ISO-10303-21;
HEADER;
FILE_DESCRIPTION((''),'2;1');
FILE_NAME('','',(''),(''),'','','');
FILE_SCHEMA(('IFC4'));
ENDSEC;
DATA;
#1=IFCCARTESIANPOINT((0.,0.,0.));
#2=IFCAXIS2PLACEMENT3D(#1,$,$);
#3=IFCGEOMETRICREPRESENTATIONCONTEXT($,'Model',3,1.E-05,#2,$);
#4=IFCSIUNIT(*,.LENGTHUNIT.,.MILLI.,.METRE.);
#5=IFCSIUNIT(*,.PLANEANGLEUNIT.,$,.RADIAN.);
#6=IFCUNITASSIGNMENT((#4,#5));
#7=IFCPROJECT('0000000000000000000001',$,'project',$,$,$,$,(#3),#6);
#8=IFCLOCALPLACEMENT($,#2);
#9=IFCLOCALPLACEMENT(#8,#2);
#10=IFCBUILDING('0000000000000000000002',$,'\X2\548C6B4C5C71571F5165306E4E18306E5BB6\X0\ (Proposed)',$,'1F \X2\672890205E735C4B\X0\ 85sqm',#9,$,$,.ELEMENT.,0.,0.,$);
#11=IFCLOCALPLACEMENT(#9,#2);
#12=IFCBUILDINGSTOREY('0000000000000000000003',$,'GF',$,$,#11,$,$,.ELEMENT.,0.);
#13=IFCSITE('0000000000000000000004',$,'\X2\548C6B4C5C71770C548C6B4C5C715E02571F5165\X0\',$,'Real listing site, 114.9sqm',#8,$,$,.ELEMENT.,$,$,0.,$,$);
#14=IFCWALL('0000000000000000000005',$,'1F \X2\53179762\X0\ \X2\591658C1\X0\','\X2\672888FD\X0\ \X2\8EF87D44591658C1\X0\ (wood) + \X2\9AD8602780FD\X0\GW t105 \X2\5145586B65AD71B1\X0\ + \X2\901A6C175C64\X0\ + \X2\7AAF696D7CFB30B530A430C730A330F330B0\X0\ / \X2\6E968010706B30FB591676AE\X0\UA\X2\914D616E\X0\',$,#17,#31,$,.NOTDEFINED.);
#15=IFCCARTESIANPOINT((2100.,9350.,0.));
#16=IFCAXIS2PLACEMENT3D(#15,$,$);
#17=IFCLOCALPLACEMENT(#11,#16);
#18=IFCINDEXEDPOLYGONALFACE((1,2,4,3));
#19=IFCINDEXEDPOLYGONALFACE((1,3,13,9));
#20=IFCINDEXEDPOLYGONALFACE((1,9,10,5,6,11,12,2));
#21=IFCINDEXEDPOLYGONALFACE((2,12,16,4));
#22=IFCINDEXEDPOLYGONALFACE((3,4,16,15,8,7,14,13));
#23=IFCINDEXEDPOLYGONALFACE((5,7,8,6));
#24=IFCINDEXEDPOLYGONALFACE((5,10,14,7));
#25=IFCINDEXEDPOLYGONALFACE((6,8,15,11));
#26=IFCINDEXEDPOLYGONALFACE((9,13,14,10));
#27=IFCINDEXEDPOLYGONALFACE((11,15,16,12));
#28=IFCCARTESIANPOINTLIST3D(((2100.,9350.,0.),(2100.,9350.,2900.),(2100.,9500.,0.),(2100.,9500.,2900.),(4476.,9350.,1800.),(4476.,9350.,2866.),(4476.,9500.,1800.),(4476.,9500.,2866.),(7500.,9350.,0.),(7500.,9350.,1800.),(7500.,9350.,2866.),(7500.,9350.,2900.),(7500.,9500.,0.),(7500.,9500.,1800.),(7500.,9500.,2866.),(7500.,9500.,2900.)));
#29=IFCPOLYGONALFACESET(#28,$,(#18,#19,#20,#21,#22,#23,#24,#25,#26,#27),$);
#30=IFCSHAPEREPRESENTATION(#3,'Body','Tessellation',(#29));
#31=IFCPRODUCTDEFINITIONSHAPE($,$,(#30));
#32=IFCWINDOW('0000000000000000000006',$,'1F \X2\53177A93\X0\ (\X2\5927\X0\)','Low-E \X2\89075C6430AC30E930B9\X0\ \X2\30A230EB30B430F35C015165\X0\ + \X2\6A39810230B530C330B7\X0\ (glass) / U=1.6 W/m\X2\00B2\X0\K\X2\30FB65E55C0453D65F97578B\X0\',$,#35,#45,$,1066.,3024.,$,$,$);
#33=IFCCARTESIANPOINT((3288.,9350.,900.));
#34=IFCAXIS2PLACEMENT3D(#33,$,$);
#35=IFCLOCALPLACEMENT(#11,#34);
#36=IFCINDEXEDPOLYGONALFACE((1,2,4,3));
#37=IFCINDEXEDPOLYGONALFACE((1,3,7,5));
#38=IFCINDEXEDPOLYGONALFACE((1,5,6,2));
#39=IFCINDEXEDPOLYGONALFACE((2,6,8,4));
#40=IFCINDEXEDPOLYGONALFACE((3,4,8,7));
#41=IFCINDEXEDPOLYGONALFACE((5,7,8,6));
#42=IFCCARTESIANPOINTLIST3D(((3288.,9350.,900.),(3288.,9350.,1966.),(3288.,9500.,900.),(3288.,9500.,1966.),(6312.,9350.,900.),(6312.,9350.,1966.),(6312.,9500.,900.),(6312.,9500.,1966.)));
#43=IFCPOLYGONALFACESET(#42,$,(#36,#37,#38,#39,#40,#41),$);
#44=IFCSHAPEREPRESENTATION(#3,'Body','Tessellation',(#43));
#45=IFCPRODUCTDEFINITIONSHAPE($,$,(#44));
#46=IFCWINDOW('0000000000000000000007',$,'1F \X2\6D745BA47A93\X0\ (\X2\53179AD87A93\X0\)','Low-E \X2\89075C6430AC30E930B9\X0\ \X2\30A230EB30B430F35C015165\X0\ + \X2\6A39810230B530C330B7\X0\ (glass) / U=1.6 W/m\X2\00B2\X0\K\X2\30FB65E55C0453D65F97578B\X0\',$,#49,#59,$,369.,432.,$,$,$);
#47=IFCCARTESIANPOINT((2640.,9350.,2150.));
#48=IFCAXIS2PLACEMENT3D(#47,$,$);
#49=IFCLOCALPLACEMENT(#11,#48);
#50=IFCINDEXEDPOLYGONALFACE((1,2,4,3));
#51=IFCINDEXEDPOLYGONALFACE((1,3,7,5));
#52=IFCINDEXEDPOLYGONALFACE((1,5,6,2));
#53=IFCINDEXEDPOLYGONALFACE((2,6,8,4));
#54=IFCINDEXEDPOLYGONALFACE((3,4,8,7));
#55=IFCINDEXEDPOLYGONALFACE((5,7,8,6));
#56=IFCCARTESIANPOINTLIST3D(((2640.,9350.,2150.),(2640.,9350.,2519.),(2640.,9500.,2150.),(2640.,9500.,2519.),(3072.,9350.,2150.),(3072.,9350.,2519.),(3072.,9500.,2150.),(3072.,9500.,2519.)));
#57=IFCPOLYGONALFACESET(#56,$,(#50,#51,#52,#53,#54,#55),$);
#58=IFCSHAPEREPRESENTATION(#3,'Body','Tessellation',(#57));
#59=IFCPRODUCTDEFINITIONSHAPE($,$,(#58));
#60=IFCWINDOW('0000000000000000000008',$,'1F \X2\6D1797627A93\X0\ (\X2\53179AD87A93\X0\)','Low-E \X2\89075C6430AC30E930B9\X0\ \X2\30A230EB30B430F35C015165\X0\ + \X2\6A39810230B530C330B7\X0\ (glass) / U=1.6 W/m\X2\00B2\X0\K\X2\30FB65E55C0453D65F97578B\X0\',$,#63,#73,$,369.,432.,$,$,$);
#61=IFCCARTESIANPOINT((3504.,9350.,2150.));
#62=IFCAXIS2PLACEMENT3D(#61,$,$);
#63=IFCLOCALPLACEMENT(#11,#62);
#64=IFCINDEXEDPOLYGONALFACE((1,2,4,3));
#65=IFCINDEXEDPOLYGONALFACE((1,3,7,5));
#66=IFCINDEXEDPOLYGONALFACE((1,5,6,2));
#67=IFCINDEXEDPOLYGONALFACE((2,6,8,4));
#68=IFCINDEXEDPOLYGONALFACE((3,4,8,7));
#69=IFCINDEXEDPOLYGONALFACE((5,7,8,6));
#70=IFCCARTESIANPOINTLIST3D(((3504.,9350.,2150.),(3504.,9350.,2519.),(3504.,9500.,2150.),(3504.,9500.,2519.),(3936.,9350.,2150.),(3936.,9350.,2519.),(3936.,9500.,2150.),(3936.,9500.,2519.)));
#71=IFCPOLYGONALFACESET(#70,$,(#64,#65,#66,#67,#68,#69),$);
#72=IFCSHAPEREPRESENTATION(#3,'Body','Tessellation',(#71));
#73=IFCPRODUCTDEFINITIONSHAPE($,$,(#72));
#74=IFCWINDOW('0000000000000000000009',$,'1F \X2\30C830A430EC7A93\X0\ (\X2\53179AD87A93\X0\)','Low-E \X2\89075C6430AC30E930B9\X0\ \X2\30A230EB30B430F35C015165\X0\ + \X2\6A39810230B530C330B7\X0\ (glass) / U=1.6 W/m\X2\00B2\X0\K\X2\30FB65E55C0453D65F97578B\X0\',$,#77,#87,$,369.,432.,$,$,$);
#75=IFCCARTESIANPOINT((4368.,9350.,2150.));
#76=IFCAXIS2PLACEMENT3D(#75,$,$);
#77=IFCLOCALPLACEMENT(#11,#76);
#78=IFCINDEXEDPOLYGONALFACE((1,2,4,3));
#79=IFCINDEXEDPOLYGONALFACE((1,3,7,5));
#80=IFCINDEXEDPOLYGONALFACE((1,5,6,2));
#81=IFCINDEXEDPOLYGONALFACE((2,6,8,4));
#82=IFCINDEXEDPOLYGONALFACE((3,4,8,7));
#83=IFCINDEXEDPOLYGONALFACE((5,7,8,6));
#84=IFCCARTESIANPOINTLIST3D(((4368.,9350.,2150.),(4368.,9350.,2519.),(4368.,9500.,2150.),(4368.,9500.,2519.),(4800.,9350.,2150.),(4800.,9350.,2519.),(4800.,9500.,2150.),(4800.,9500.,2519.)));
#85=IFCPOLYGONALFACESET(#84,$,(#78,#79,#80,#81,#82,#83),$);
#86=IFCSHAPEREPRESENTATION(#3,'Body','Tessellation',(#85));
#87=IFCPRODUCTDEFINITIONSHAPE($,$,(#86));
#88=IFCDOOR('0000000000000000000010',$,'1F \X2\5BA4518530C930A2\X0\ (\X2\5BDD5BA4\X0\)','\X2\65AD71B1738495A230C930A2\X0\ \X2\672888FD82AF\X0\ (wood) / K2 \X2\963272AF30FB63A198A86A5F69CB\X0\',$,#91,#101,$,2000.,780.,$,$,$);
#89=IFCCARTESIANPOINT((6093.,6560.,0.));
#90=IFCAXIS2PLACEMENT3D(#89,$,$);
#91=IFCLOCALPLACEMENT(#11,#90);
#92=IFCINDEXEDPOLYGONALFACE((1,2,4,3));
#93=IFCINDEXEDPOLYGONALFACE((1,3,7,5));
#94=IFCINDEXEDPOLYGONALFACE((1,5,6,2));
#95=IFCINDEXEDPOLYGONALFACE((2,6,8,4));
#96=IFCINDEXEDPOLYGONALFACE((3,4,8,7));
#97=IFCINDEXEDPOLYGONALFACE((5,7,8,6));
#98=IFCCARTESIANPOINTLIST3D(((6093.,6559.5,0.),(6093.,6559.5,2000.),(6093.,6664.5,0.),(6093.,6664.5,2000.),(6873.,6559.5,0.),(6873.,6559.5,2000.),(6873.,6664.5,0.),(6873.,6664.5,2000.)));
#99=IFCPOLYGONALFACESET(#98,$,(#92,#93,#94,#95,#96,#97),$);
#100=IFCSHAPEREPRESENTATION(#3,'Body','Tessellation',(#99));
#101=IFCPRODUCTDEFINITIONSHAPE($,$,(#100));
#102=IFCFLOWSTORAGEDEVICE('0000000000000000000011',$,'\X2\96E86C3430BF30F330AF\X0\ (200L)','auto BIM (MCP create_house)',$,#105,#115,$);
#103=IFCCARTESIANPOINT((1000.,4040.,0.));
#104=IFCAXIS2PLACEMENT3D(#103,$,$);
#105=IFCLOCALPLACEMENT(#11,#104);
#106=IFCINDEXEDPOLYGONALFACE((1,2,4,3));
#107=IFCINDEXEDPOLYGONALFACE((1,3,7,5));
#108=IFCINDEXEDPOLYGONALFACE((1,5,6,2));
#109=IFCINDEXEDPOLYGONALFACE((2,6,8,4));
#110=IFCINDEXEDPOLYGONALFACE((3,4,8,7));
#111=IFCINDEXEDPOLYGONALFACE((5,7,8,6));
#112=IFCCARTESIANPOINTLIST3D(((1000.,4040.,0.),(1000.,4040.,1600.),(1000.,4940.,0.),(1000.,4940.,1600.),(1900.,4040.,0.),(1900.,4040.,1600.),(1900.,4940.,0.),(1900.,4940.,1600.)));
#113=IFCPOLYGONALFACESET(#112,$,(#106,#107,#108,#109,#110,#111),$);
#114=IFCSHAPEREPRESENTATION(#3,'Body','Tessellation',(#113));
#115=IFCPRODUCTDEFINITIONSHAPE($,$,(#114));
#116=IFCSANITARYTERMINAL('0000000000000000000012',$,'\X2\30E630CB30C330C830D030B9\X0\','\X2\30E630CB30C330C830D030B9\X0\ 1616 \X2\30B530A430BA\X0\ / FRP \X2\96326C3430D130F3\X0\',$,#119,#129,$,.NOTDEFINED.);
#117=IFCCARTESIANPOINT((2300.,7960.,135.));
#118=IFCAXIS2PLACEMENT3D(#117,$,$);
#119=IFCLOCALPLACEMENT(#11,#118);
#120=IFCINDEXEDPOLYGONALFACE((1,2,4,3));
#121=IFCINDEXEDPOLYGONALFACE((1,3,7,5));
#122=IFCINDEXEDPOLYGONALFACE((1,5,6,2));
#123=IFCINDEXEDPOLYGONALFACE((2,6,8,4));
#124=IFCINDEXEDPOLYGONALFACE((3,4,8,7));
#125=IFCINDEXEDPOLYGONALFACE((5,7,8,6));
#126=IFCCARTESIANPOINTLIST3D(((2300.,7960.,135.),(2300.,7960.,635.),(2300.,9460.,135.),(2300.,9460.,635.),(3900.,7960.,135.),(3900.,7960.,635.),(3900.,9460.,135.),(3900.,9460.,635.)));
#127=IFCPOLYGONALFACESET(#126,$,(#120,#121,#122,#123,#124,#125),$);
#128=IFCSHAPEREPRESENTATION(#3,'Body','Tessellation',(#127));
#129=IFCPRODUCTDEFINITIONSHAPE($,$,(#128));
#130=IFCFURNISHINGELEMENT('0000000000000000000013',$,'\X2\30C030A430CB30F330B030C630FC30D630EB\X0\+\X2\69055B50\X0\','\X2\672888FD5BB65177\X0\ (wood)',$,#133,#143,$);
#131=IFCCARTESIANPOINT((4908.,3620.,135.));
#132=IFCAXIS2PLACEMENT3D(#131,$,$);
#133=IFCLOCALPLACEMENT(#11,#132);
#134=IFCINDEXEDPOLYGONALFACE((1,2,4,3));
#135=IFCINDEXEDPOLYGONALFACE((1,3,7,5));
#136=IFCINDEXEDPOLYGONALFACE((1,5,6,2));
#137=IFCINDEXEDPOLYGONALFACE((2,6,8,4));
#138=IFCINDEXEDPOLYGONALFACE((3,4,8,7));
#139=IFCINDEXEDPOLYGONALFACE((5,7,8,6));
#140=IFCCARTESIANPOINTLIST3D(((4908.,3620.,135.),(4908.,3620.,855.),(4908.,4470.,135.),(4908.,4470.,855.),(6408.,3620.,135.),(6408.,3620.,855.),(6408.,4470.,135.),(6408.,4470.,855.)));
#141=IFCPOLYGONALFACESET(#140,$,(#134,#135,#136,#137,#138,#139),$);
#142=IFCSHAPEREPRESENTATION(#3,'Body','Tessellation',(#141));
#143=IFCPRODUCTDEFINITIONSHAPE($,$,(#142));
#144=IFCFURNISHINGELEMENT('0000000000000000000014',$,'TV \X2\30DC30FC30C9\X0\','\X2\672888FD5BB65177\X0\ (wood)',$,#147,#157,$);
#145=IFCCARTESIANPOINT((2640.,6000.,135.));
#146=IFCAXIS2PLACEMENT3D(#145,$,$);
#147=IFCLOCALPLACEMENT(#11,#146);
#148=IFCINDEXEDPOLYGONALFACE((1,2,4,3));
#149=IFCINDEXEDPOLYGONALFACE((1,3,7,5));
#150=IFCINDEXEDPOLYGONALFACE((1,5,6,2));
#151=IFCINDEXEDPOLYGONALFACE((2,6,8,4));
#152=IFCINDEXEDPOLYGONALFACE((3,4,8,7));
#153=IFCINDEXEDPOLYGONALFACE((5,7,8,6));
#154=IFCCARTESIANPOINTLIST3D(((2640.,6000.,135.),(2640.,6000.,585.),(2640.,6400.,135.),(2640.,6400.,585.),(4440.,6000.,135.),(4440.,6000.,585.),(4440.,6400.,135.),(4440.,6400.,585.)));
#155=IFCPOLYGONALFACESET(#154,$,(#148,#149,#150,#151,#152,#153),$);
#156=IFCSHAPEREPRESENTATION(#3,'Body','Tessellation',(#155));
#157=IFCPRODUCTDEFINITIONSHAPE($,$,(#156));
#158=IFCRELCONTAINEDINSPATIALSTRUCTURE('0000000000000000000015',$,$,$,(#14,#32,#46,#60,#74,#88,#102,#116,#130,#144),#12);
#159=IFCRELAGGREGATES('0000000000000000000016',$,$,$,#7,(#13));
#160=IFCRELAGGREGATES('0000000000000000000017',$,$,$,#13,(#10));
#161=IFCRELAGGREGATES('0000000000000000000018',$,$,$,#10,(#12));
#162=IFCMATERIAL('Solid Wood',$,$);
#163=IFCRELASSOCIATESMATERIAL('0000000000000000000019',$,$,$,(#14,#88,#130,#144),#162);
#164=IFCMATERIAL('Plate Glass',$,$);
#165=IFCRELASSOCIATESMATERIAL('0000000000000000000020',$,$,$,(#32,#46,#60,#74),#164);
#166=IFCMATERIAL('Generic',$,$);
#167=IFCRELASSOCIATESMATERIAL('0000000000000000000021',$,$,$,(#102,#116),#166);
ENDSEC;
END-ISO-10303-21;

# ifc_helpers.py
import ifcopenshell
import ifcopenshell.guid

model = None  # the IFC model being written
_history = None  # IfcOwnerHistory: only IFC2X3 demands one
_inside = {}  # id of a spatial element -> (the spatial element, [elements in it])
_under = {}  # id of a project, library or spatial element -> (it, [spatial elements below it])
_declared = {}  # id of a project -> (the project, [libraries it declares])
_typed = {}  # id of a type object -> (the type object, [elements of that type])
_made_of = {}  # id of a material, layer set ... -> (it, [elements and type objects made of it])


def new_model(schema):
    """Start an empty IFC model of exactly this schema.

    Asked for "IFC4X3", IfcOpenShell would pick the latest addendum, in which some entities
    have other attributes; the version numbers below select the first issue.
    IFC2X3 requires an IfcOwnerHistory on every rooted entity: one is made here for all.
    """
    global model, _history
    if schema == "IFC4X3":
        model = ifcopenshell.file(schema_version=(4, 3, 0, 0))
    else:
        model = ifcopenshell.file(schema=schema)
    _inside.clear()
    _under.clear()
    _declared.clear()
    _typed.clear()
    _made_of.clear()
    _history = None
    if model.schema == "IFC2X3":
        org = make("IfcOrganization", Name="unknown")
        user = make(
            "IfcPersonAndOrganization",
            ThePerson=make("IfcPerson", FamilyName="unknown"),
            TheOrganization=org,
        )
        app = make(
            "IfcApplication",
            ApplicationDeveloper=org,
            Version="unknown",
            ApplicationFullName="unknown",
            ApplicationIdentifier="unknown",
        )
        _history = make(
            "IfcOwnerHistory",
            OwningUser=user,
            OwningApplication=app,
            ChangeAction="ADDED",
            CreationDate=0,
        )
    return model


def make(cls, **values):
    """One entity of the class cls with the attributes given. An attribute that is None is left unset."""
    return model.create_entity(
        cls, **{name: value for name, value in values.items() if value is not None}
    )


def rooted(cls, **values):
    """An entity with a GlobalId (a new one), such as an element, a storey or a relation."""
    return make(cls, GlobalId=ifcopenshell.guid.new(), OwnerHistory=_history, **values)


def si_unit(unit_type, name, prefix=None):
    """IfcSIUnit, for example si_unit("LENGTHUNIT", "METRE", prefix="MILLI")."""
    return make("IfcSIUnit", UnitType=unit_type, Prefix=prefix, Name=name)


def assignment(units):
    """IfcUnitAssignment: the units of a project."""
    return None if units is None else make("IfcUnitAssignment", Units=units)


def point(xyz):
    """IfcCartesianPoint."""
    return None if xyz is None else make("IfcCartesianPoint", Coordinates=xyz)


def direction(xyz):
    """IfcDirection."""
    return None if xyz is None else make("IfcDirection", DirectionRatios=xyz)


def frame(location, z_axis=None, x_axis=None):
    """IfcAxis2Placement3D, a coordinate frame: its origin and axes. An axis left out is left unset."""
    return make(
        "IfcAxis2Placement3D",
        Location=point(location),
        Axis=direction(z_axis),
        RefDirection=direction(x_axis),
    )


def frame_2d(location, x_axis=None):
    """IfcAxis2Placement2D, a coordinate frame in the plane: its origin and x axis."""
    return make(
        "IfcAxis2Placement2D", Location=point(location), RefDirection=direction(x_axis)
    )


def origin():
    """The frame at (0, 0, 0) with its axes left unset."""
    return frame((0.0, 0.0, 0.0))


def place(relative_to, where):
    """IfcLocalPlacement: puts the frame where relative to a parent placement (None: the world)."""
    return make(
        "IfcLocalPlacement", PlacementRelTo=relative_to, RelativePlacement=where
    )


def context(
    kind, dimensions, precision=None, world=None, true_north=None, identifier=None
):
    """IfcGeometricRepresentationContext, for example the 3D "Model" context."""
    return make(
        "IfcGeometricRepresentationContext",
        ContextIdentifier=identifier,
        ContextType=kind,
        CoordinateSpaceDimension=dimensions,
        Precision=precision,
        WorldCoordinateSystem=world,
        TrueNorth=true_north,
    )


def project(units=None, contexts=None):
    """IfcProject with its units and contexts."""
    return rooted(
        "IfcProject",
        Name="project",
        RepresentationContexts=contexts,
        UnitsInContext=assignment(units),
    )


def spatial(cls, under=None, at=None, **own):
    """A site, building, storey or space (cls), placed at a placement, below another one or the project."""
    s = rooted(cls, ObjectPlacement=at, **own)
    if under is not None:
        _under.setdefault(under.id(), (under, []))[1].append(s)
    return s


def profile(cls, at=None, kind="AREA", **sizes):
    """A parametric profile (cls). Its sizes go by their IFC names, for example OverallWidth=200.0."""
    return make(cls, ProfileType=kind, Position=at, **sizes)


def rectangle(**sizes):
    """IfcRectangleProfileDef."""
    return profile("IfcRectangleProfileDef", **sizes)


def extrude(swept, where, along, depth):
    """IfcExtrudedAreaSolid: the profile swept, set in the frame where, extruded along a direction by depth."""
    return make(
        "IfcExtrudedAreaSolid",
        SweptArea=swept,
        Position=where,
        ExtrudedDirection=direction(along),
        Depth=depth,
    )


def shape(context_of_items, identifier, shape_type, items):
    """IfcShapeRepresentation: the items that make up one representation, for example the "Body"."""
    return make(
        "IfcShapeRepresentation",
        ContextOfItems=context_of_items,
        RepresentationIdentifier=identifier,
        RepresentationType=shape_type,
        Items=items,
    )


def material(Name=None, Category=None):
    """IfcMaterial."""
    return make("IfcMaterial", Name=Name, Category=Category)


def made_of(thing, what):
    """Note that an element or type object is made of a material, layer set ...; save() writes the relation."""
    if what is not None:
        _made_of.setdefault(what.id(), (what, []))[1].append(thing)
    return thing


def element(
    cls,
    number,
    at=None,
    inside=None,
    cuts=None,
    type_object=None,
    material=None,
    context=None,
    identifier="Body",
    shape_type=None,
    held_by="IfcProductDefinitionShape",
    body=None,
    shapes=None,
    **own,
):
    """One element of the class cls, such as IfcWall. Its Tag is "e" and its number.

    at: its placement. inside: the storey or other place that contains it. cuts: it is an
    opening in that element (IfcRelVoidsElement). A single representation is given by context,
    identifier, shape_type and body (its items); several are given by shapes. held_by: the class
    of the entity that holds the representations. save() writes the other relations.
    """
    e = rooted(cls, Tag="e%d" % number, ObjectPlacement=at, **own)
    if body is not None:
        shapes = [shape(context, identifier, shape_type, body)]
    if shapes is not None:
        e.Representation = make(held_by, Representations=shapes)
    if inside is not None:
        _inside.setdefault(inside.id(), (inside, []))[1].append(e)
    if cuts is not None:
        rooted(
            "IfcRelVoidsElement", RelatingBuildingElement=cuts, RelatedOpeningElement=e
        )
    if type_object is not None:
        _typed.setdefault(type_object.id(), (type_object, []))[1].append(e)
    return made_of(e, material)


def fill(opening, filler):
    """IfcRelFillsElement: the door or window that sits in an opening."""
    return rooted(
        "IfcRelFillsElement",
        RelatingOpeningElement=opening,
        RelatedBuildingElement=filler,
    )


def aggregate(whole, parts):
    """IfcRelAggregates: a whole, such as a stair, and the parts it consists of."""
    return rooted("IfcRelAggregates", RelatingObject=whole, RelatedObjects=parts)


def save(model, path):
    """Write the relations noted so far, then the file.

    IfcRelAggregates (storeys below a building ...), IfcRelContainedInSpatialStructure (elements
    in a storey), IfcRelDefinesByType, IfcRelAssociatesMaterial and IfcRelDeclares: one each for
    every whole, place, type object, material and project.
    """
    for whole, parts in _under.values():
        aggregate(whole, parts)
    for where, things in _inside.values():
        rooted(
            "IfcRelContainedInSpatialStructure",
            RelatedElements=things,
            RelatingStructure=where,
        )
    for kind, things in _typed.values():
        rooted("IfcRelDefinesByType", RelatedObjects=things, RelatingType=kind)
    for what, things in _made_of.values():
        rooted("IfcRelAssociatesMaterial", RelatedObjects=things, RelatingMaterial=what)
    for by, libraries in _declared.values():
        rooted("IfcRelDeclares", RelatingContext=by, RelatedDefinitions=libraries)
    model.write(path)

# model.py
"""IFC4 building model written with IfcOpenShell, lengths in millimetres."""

from ifc_helpers import new_model, si_unit, frame, frame_2d, origin, place, context, project, spatial, rectangle, extrude, material, element, fill, save


model = new_model("IFC4")

# Units and contexts
model_context = context("Model", 3, precision=1e-05, world=origin())
ifc_project = project(units=[si_unit("LENGTHUNIT", "METRE", prefix="MILLI"), si_unit("PLANEANGLEUNIT", "RADIAN")], contexts=[model_context])

# Site, building, storey
site_placement = place(None, origin())
site = spatial("IfcSite", under=ifc_project, at=site_placement, Name="和歌山県和歌山市土入", ObjectType="Real listing site, 114.9sqm", CompositionType="ELEMENT", RefElevation=0.0)
building_placement = place(site_placement, origin())
building = spatial("IfcBuilding", under=site, at=building_placement, Name="和歌山土入の丘の家 (Proposed)", ObjectType="1F 木造平屋 85sqm", CompositionType="ELEMENT", ElevationOfRefHeight=0.0, ElevationOfTerrain=0.0)
storey_placement = place(building_placement, origin())
storey = spatial("IfcBuildingStorey", under=building, at=storey_placement, Name="GF", CompositionType="ELEMENT", Elevation=0.0)

# Wall, openings, windows
ifc_material_1 = material(Name="Solid Wood")
wall_1_placement = place(storey_placement, frame((2100.0, 9350.0, 0.0)))
wall_1 = element("IfcWall", 1, at=wall_1_placement, inside=storey, material=ifc_material_1, Name="1F 北面 外壁", Description="木製 軸組外壁 (wood) + 高性能GW t105 充填断熱 + 通気層 + 窯業系サイディング / 準耐火・外皮UA配慮", PredefinedType="NOTDEFINED", context=model_context, shape_type="SweptSolid", body=[
    extrude(rectangle(XDim=5400.0, YDim=150.0, at=frame_2d((2700.0, 75.0))), frame((2100.0, 9350.0, 0.0)), (0.0, 0.0, 1.0), 2900.0),
])
opening_1_placement = place(storey_placement, frame((3288.0, 9350.0, 900.0)))
opening_1 = element("IfcOpeningElement", 2, at=opening_1_placement, cuts=wall_1, PredefinedType="NOTDEFINED", context=model_context, shape_type="SweptSolid", body=[
    extrude(rectangle(XDim=3024.0, YDim=150.0, at=frame_2d((1512.0, 75.0))), frame((3288.0, 9350.0, 900.0)), (0.0, 0.0, 1.0), 1066.0),
])
opening_2_placement = place(storey_placement, frame((2640.0, 9350.0, 2150.0)))
opening_2 = element("IfcOpeningElement", 3, at=opening_2_placement, cuts=wall_1, PredefinedType="NOTDEFINED", context=model_context, shape_type="SweptSolid", body=[
    extrude(rectangle(XDim=432.0, YDim=150.0, at=frame_2d((216.0, 75.0))), frame((2640.0, 9350.0, 2150.0)), (0.0, 0.0, 1.0), 369.0),
])
opening_3_placement = place(storey_placement, frame((3504.0, 9350.0, 2150.0)))
opening_3 = element("IfcOpeningElement", 4, at=opening_3_placement, cuts=wall_1, PredefinedType="NOTDEFINED", context=model_context, shape_type="SweptSolid", body=[
    extrude(rectangle(XDim=432.0, YDim=150.0, at=frame_2d((216.0, 75.0))), frame((3504.0, 9350.0, 2150.0)), (0.0, 0.0, 1.0), 369.0),
])
opening_4_placement = place(storey_placement, frame((4368.0, 9350.0, 2150.0)))
opening_4 = element("IfcOpeningElement", 5, at=opening_4_placement, cuts=wall_1, PredefinedType="NOTDEFINED", context=model_context, shape_type="SweptSolid", body=[
    extrude(rectangle(XDim=432.0, YDim=150.0, at=frame_2d((216.0, 75.0))), frame((4368.0, 9350.0, 2150.0)), (0.0, 0.0, 1.0), 369.0),
])
ifc_material_2 = material(Name="Plate Glass")
window_1_placement = place(storey_placement, frame((3288.0, 9350.0, 900.0)))
window_1 = element("IfcWindow", 6, at=window_1_placement, inside=storey, material=ifc_material_2, Name="1F 北窓 (大)", Description="Low-E 複層ガラス アルゴン封入 + 樹脂サッシ (glass) / U=1.6 W/m²K・日射取得型", OverallHeight=1066.0, OverallWidth=3024.0, context=model_context, shape_type="SweptSolid", body=[
    extrude(rectangle(XDim=3024.0, YDim=150.0, at=frame_2d((1512.0, 75.0))), frame((3288.0, 9350.0, 900.0)), (0.0, 0.0, 1.0), 1066.0),
])
fill(opening_1, window_1)
window_2_placement = place(storey_placement, frame((2640.0, 9350.0, 2150.0)))
window_2 = element("IfcWindow", 7, at=window_2_placement, inside=storey, material=ifc_material_2, Name="1F 浴室窓 (北高窓)", Description="Low-E 複層ガラス アルゴン封入 + 樹脂サッシ (glass) / U=1.6 W/m²K・日射取得型", OverallHeight=369.0, OverallWidth=432.0, context=model_context, shape_type="SweptSolid", body=[
    extrude(rectangle(XDim=432.0, YDim=150.0, at=frame_2d((216.0, 75.0))), frame((2640.0, 9350.0, 2150.0)), (0.0, 0.0, 1.0), 369.0),
])
fill(opening_2, window_2)
window_3_placement = place(storey_placement, frame((3504.0, 9350.0, 2150.0)))
window_3 = element("IfcWindow", 8, at=window_3_placement, inside=storey, material=ifc_material_2, Name="1F 洗面窓 (北高窓)", Description="Low-E 複層ガラス アルゴン封入 + 樹脂サッシ (glass) / U=1.6 W/m²K・日射取得型", OverallHeight=369.0, OverallWidth=432.0, context=model_context, shape_type="SweptSolid", body=[
    extrude(rectangle(XDim=432.0, YDim=150.0, at=frame_2d((216.0, 75.0))), frame((3504.0, 9350.0, 2150.0)), (0.0, 0.0, 1.0), 369.0),
])
fill(opening_3, window_3)
window_4_placement = place(storey_placement, frame((4368.0, 9350.0, 2150.0)))
window_4 = element("IfcWindow", 9, at=window_4_placement, inside=storey, material=ifc_material_2, Name="1F トイレ窓 (北高窓)", Description="Low-E 複層ガラス アルゴン封入 + 樹脂サッシ (glass) / U=1.6 W/m²K・日射取得型", OverallHeight=369.0, OverallWidth=432.0, context=model_context, shape_type="SweptSolid", body=[
    extrude(rectangle(XDim=432.0, YDim=150.0, at=frame_2d((216.0, 75.0))), frame((4368.0, 9350.0, 2150.0)), (0.0, 0.0, 1.0), 369.0),
])
fill(opening_4, window_4)

# Door
door_1_placement = place(storey_placement, frame((6093.0, 6560.0, 0.0)))
element("IfcDoor", 10, at=door_1_placement, inside=storey, material=ifc_material_1, Name="1F 室内ドア (寝室)", Description="断熱玄関ドア 木製芯 (wood) / K2 防犯・採風機構", OverallHeight=2000.0, OverallWidth=780.0, context=model_context, shape_type="SweptSolid", body=[
    extrude(rectangle(XDim=780.0, YDim=105.0, at=frame_2d((390.0, 52.0))), frame((6093.0, 6560.0, 0.0)), (0.0, 0.0, 1.0), 2000.0),
])

# Flow storage device
ifc_material_3 = material(Name="Generic")
flow_storage_device_placement = place(storey_placement, frame((1000.0, 4040.0, 0.0)))
element("IfcFlowStorageDevice", 11, at=flow_storage_device_placement, inside=storey, material=ifc_material_3, Name="雨水タンク (200L)", Description="auto BIM (MCP create_house)", context=model_context, shape_type="SweptSolid", body=[
    extrude(rectangle(XDim=900.0, YDim=900.0, at=frame_2d((450.0, 450.0))), frame((1000.0, 4040.0, 0.0)), (0.0, 0.0, 1.0), 1600.0),
])

# Sanitary terminal
sanitary_terminal_placement = place(storey_placement, frame((2300.0, 7960.0, 135.0)))
element("IfcSanitaryTerminal", 12, at=sanitary_terminal_placement, inside=storey, material=ifc_material_3, Name="ユニットバス", Description="ユニットバス 1616 サイズ / FRP 防水パン", PredefinedType="NOTDEFINED", context=model_context, shape_type="SweptSolid", body=[
    extrude(rectangle(XDim=1600.0, YDim=1500.0, at=frame_2d((800.0, 750.0))), frame((2300.0, 7960.0, 135.0)), (0.0, 0.0, 1.0), 500.0),
])

# Furnishing elements
furnishing_1_placement = place(storey_placement, frame((4908.0, 3620.0, 135.0)))
element("IfcFurnishingElement", 13, at=furnishing_1_placement, inside=storey, material=ifc_material_1, Name="ダイニングテーブル+椅子", Description="木製家具 (wood)", context=model_context, shape_type="SweptSolid", body=[
    extrude(rectangle(XDim=1500.0, YDim=850.0, at=frame_2d((750.0, 425.0))), frame((4908.0, 3620.0, 135.0)), (0.0, 0.0, 1.0), 720.0),
])
furnishing_2_placement = place(storey_placement, frame((2640.0, 6000.0, 135.0)))
element("IfcFurnishingElement", 14, at=furnishing_2_placement, inside=storey, material=ifc_material_1, Name="TV ボード", Description="木製家具 (wood)", context=model_context, shape_type="SweptSolid", body=[
    extrude(rectangle(XDim=1800.0, YDim=400.0, at=frame_2d((900.0, 200.0))), frame((2640.0, 6000.0, 135.0)), (0.0, 0.0, 1.0), 450.0),
])

save(model, "model.ifc")
